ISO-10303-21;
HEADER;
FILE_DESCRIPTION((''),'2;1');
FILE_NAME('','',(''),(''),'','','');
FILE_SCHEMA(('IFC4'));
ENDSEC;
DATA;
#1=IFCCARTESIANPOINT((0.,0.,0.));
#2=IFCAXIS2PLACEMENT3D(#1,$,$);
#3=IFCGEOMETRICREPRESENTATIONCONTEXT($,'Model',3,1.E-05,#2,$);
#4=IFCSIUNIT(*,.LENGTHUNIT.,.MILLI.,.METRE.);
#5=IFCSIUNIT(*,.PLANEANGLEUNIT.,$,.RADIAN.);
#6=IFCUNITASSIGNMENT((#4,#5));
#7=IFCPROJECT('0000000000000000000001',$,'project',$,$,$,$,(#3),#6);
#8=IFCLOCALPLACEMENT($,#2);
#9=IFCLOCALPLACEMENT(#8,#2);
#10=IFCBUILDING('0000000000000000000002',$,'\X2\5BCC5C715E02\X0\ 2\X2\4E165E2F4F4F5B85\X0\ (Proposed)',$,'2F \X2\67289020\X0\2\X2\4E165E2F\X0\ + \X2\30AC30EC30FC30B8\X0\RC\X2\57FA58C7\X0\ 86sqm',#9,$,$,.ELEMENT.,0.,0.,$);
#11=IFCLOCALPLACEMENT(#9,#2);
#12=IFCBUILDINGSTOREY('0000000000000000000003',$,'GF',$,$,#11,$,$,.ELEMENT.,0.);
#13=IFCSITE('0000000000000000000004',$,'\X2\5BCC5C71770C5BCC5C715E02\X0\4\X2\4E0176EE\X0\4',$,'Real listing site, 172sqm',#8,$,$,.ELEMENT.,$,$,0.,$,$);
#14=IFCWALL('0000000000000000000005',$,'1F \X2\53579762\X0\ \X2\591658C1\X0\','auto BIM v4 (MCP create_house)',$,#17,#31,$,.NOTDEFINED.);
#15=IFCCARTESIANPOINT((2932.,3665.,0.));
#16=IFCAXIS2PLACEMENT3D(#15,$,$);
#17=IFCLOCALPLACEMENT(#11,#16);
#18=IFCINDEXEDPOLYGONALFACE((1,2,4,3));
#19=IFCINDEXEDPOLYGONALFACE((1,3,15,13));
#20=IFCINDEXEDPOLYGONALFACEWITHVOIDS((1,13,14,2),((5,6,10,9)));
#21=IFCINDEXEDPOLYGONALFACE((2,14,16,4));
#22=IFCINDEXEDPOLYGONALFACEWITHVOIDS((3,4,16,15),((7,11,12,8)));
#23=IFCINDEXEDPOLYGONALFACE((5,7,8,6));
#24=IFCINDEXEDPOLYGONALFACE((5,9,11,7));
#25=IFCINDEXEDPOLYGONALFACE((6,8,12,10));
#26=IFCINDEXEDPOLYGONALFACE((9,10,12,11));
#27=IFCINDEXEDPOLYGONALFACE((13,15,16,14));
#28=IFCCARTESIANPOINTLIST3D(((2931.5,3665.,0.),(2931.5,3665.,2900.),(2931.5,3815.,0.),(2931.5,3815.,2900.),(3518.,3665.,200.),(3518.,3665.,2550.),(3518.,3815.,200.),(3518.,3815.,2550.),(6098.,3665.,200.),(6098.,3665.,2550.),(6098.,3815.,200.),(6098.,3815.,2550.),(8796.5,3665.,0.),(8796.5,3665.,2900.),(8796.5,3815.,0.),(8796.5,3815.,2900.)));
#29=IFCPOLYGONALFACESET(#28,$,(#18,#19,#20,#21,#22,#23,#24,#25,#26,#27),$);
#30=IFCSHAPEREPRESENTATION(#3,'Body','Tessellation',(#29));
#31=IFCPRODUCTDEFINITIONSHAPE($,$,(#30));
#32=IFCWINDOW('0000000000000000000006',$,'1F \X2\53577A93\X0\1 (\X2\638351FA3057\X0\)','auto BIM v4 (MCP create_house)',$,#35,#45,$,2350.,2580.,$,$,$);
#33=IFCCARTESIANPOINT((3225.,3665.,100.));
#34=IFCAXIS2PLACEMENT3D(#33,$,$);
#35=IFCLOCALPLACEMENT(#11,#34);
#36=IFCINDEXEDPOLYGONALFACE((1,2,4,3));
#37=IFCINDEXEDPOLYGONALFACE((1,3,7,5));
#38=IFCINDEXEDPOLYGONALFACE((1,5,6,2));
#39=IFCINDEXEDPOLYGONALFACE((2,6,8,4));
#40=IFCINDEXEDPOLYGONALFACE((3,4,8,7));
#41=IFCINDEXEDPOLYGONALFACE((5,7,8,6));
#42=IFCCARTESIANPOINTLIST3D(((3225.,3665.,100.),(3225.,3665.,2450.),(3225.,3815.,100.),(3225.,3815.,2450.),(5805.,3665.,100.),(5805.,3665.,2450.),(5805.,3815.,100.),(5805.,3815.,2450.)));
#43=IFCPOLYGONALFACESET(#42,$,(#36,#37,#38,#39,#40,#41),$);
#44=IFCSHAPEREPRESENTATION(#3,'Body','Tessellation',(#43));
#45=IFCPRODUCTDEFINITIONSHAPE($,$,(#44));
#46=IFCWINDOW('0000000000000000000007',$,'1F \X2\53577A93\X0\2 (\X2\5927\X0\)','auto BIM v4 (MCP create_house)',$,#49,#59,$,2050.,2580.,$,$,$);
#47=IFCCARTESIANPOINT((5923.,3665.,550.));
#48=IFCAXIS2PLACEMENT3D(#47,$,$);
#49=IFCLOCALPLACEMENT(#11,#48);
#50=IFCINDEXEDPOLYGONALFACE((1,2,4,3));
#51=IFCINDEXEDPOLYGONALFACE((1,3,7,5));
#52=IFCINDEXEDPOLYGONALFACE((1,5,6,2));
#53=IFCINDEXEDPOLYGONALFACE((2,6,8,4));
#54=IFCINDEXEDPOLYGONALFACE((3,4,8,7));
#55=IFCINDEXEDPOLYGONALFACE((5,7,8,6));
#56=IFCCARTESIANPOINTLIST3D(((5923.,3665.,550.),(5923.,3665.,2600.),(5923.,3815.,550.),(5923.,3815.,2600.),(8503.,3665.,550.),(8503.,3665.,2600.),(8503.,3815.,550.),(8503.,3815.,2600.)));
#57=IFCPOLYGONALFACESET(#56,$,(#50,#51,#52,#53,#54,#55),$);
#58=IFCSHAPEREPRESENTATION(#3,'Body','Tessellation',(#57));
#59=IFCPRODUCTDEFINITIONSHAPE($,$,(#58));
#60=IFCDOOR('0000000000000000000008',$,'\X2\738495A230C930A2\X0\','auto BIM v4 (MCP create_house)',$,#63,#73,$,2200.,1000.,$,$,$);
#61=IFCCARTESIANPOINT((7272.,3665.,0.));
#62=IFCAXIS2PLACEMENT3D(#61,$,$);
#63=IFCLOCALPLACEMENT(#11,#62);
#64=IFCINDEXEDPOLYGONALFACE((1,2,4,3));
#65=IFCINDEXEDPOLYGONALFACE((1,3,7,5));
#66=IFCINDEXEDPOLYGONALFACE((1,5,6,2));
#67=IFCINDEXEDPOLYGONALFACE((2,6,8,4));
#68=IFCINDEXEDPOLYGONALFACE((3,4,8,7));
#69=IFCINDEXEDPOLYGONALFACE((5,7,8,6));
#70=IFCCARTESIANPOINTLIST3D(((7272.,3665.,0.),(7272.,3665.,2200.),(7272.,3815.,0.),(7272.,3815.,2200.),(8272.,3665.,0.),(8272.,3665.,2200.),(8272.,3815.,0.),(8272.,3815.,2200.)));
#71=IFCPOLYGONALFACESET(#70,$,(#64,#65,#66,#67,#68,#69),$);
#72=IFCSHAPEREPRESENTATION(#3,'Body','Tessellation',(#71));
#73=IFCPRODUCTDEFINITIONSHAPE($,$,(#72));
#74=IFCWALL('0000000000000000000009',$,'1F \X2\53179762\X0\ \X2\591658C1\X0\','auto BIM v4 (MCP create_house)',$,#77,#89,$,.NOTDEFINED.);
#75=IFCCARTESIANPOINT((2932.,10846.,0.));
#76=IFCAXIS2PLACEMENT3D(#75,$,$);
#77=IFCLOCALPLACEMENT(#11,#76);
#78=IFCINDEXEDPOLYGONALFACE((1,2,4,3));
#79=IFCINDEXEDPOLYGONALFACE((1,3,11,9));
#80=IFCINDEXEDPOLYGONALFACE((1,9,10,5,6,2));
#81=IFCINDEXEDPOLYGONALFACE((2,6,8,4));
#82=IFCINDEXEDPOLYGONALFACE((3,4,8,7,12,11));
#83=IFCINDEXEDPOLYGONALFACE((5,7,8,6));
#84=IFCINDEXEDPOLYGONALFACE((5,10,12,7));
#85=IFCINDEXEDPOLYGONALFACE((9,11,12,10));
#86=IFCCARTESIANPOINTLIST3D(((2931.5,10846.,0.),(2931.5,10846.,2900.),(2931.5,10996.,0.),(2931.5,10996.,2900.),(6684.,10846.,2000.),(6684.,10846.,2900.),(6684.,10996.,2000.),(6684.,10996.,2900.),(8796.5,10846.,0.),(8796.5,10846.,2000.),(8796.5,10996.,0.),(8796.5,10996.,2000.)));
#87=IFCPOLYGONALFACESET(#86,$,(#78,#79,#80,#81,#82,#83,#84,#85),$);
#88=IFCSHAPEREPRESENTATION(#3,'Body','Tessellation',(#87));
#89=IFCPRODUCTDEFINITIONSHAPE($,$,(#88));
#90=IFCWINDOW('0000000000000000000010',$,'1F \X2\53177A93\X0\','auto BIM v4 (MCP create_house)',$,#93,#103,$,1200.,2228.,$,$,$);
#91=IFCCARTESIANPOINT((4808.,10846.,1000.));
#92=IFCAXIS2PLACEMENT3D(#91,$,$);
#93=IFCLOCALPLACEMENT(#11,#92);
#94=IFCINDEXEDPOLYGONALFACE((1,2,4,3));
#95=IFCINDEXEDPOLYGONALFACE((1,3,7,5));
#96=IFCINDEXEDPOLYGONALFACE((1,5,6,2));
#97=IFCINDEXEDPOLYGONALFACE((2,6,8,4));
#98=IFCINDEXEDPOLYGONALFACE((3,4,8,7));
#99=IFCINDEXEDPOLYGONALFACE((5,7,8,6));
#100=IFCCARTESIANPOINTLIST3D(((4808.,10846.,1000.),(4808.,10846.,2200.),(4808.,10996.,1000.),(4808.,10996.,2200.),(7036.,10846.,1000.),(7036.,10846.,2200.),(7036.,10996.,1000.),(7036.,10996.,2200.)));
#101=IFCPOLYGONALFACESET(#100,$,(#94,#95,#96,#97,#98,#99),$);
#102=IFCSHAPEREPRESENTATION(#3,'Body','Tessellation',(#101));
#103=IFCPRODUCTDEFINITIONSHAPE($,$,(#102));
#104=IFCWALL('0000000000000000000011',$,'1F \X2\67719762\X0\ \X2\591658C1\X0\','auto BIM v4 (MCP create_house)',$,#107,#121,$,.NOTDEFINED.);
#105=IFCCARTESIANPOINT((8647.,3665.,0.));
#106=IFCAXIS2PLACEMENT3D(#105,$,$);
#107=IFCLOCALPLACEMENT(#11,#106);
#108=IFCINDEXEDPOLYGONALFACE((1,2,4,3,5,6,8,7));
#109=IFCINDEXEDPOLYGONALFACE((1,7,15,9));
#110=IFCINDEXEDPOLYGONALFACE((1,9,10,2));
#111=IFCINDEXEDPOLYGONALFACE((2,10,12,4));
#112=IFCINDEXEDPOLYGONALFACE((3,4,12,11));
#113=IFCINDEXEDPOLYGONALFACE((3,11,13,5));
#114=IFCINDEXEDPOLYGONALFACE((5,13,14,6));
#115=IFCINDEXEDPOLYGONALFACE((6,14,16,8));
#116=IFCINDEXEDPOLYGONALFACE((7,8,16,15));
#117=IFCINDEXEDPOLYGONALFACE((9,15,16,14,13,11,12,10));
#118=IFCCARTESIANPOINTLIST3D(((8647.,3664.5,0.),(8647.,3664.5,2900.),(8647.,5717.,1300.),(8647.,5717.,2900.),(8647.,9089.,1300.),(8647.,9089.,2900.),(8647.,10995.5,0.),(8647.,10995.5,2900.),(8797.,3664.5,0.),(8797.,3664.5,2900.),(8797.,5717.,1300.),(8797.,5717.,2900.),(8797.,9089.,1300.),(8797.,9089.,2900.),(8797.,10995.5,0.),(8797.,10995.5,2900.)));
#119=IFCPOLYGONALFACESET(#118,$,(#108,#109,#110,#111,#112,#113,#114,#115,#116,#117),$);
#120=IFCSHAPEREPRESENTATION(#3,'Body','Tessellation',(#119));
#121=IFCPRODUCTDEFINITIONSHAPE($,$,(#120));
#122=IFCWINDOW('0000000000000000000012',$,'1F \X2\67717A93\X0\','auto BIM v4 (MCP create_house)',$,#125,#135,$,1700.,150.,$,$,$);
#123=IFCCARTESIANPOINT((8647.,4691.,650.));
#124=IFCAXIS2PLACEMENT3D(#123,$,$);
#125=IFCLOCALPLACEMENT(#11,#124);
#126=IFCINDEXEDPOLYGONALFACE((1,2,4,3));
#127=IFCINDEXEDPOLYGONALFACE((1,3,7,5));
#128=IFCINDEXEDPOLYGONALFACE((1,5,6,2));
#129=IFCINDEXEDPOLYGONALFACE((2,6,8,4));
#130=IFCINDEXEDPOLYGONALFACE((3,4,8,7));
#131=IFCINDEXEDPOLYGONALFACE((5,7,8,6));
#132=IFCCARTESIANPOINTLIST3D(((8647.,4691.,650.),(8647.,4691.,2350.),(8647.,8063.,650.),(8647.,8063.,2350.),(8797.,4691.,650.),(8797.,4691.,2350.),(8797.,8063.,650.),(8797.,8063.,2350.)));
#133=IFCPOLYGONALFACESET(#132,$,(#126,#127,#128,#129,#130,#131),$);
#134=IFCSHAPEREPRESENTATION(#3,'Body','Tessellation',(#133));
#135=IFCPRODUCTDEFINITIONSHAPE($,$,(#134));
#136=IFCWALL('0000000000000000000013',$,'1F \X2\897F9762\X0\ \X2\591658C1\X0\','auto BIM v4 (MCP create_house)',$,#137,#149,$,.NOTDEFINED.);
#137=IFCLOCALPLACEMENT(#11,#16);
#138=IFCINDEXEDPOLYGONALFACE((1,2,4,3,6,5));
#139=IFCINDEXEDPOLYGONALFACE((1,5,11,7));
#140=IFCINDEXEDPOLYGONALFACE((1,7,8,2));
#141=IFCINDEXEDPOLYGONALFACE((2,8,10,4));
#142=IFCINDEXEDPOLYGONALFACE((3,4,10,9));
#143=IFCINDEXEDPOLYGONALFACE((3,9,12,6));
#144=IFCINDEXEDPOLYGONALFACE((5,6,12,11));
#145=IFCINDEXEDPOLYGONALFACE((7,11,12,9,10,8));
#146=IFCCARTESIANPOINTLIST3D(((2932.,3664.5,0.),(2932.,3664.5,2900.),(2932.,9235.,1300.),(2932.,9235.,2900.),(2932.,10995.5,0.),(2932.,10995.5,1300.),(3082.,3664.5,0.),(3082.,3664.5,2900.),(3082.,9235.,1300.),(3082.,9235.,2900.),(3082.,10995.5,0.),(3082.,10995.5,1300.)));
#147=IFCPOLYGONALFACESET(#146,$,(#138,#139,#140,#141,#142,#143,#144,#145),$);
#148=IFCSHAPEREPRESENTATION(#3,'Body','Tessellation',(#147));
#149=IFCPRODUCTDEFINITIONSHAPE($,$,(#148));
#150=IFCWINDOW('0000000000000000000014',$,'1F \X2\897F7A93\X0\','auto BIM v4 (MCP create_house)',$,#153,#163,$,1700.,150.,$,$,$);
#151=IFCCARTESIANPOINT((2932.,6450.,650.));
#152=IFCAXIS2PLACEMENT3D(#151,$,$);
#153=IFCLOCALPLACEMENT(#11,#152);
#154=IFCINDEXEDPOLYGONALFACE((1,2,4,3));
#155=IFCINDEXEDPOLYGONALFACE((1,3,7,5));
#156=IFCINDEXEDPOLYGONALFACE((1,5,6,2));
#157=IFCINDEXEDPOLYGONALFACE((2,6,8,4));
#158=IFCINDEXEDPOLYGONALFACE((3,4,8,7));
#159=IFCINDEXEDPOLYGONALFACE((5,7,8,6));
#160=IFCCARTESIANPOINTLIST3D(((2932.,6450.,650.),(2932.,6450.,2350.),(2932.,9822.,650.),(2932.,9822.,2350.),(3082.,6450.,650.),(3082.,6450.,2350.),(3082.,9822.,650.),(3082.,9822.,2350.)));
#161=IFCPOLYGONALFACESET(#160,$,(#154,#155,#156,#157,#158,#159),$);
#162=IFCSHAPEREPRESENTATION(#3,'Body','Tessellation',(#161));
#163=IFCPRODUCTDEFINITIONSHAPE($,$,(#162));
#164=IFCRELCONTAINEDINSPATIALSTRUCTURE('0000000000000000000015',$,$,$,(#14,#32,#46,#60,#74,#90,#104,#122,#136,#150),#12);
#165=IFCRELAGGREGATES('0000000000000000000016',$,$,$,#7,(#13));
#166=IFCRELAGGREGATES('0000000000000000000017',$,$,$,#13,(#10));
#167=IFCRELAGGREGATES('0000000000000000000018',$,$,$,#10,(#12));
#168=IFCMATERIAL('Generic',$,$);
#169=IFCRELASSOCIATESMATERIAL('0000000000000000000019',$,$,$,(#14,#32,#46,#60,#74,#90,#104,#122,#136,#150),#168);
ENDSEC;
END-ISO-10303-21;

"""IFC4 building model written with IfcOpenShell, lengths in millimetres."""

from ifc_helpers import new_model, si_unit, frame, frame_2d, origin, place, context, project, spatial, rectangle, extrude, material, element, fill, save


model = new_model("IFC4")

# Units and contexts
model_context = context("Model", 3, precision=1e-05, world=origin())
ifc_project = project(units=[si_unit("LENGTHUNIT", "METRE", prefix="MILLI"), si_unit("PLANEANGLEUNIT", "RADIAN")], contexts=[model_context])

# Site, building, storey
site_placement = place(None, origin())
site = spatial("IfcSite", under=ifc_project, at=site_placement, Name="富山県富山市4丁目4", ObjectType="Real listing site, 172sqm", CompositionType="ELEMENT", RefElevation=0.0)
building_placement = place(site_placement, origin())
building = spatial("IfcBuilding", under=site, at=building_placement, Name="富山市 2世帯住宅 (Proposed)", ObjectType="2F 木造2世帯 + ガレージRC基壇 86sqm", CompositionType="ELEMENT", ElevationOfRefHeight=0.0, ElevationOfTerrain=0.0)
storey_placement = place(building_placement, origin())
storey = spatial("IfcBuildingStorey", under=building, at=storey_placement, Name="GF", CompositionType="ELEMENT", Elevation=0.0)

# Shared definitions
ifc_material = material(Name="Generic")

# Wall, openings, windows, door
wall_1_placement = place(storey_placement, frame((2932.0, 3665.0, 0.0)))
wall_1 = element("IfcWall", 1, at=wall_1_placement, inside=storey, material=ifc_material, Name="1F 南面 外壁", Description="auto BIM v4 (MCP create_house)", PredefinedType="NOTDEFINED", context=model_context, shape_type="SweptSolid", body=[
    extrude(rectangle(XDim=5865.0, YDim=150.0, at=frame_2d((2932.0, 75.0))), frame((2932.0, 3665.0, 0.0)), (0.0, 0.0, 1.0), 2900.0),
])
opening_1_placement = place(storey_placement, frame((3225.0, 3665.0, 100.0)))
opening_1 = element("IfcOpeningElement", 2, at=opening_1_placement, cuts=wall_1, PredefinedType="NOTDEFINED", context=model_context, shape_type="SweptSolid", body=[
    extrude(rectangle(XDim=2580.0, YDim=150.0, at=frame_2d((1290.0, 75.0))), frame((3225.0, 3665.0, 100.0)), (0.0, 0.0, 1.0), 2350.0),
])
opening_2_placement = place(storey_placement, frame((5923.0, 3665.0, 550.0)))
opening_2 = element("IfcOpeningElement", 3, at=opening_2_placement, cuts=wall_1, PredefinedType="NOTDEFINED", context=model_context, shape_type="SweptSolid", body=[
    extrude(rectangle(XDim=2580.0, YDim=150.0, at=frame_2d((1290.0, 75.0))), frame((5923.0, 3665.0, 550.0)), (0.0, 0.0, 1.0), 2050.0),
])
opening_3_placement = place(storey_placement, frame((7272.0, 3665.0, 0.0)))
opening_3 = element("IfcOpeningElement", 4, at=opening_3_placement, cuts=wall_1, PredefinedType="NOTDEFINED", context=model_context, shape_type="SweptSolid", body=[
    extrude(rectangle(XDim=1000.0, YDim=150.0, at=frame_2d((500.0, 75.0))), frame((7272.0, 3665.0, 0.0)), (0.0, 0.0, 1.0), 2200.0),
])
window_1_placement = place(storey_placement, frame((3225.0, 3665.0, 100.0)))
window_1 = element("IfcWindow", 5, at=window_1_placement, inside=storey, material=ifc_material, Name="1F 南窓1 (掃出し)", Description="auto BIM v4 (MCP create_house)", OverallHeight=2350.0, OverallWidth=2580.0, context=model_context, shape_type="SweptSolid", body=[
    extrude(rectangle(XDim=2580.0, YDim=150.0, at=frame_2d((1290.0, 75.0))), frame((3225.0, 3665.0, 100.0)), (0.0, 0.0, 1.0), 2350.0),
])
fill(opening_1, window_1)
window_2_placement = place(storey_placement, frame((5923.0, 3665.0, 550.0)))
window_2 = element("IfcWindow", 6, at=window_2_placement, inside=storey, material=ifc_material, Name="1F 南窓2 (大)", Description="auto BIM v4 (MCP create_house)", OverallHeight=2050.0, OverallWidth=2580.0, context=model_context, shape_type="SweptSolid", body=[
    extrude(rectangle(XDim=2580.0, YDim=150.0, at=frame_2d((1290.0, 75.0))), frame((5923.0, 3665.0, 550.0)), (0.0, 0.0, 1.0), 2050.0),
])
fill(opening_2, window_2)
door_1_placement = place(storey_placement, frame((7272.0, 3665.0, 0.0)))
door_1 = element("IfcDoor", 7, at=door_1_placement, inside=storey, material=ifc_material, Name="玄関ドア", Description="auto BIM v4 (MCP create_house)", OverallHeight=2200.0, OverallWidth=1000.0, context=model_context, shape_type="SweptSolid", body=[
    extrude(rectangle(XDim=1000.0, YDim=150.0, at=frame_2d((500.0, 75.0))), frame((7272.0, 3665.0, 0.0)), (0.0, 0.0, 1.0), 2200.0),
])
fill(opening_3, door_1)

# Walls, openings, windows
wall_2_placement = place(storey_placement, frame((2932.0, 10846.0, 0.0)))
wall_2 = element("IfcWall", 8, at=wall_2_placement, inside=storey, material=ifc_material, Name="1F 北面 外壁", Description="auto BIM v4 (MCP create_house)", PredefinedType="NOTDEFINED", context=model_context, shape_type="SweptSolid", body=[
    extrude(rectangle(XDim=5865.0, YDim=150.0, at=frame_2d((2932.0, 75.0))), frame((2932.0, 10846.0, 0.0)), (0.0, 0.0, 1.0), 2900.0),
])
opening_4_placement = place(storey_placement, frame((4808.0, 10846.0, 1000.0)))
opening_4 = element("IfcOpeningElement", 9, at=opening_4_placement, cuts=wall_2, PredefinedType="NOTDEFINED", context=model_context, shape_type="SweptSolid", body=[
    extrude(rectangle(XDim=2228.0, YDim=150.0, at=frame_2d((1114.0, 75.0))), frame((4808.0, 10846.0, 1000.0)), (0.0, 0.0, 1.0), 1200.0),
])
window_3_placement = place(storey_placement, frame((4808.0, 10846.0, 1000.0)))
window_3 = element("IfcWindow", 10, at=window_3_placement, inside=storey, material=ifc_material, Name="1F 北窓", Description="auto BIM v4 (MCP create_house)", OverallHeight=1200.0, OverallWidth=2228.0, context=model_context, shape_type="SweptSolid", body=[
    extrude(rectangle(XDim=2228.0, YDim=150.0, at=frame_2d((1114.0, 75.0))), frame((4808.0, 10846.0, 1000.0)), (0.0, 0.0, 1.0), 1200.0),
])
fill(opening_4, window_3)
wall_3_placement = place(storey_placement, frame((8647.0, 3665.0, 0.0)))
wall_3 = element("IfcWall", 11, at=wall_3_placement, inside=storey, material=ifc_material, Name="1F 東面 外壁", Description="auto BIM v4 (MCP create_house)", PredefinedType="NOTDEFINED", context=model_context, shape_type="SweptSolid", body=[
    extrude(rectangle(XDim=150.0, YDim=7331.0, at=frame_2d((75.0, 3665.0))), frame((8647.0, 3665.0, 0.0)), (0.0, 0.0, 1.0), 2900.0),
])
opening_5_placement = place(storey_placement, frame((8647.0, 4691.0, 650.0)))
opening_5 = element("IfcOpeningElement", 12, at=opening_5_placement, cuts=wall_3, PredefinedType="NOTDEFINED", context=model_context, shape_type="SweptSolid", body=[
    extrude(rectangle(XDim=150.0, YDim=3372.0, at=frame_2d((75.0, 1686.0))), frame((8647.0, 4691.0, 650.0)), (0.0, 0.0, 1.0), 1700.0),
])
window_4_placement = place(storey_placement, frame((8647.0, 4691.0, 650.0)))
window_4 = element("IfcWindow", 13, at=window_4_placement, inside=storey, material=ifc_material, Name="1F 東窓", Description="auto BIM v4 (MCP create_house)", OverallHeight=1700.0, OverallWidth=150.0, context=model_context, shape_type="SweptSolid", body=[
    extrude(rectangle(XDim=150.0, YDim=3372.0, at=frame_2d((75.0, 1686.0))), frame((8647.0, 4691.0, 650.0)), (0.0, 0.0, 1.0), 1700.0),
])
fill(opening_5, window_4)
wall_4_placement = place(storey_placement, frame((2932.0, 3665.0, 0.0)))
wall_4 = element("IfcWall", 14, at=wall_4_placement, inside=storey, material=ifc_material, Name="1F 西面 外壁", Description="auto BIM v4 (MCP create_house)", PredefinedType="NOTDEFINED", context=model_context, shape_type="SweptSolid", body=[
    extrude(rectangle(XDim=150.0, YDim=7331.0, at=frame_2d((75.0, 3665.0))), frame((2932.0, 3665.0, 0.0)), (0.0, 0.0, 1.0), 2900.0),
])
opening_6_placement = place(storey_placement, frame((2932.0, 6450.0, 650.0)))
opening_6 = element("IfcOpeningElement", 15, at=opening_6_placement, cuts=wall_4, PredefinedType="NOTDEFINED", context=model_context, shape_type="SweptSolid", body=[
    extrude(rectangle(XDim=150.0, YDim=3372.0, at=frame_2d((75.0, 1686.0))), frame((2932.0, 6450.0, 650.0)), (0.0, 0.0, 1.0), 1700.0),
])
window_5_placement = place(storey_placement, frame((2932.0, 6450.0, 650.0)))
window_5 = element("IfcWindow", 16, at=window_5_placement, inside=storey, material=ifc_material, Name="1F 西窓", Description="auto BIM v4 (MCP create_house)", OverallHeight=1700.0, OverallWidth=150.0, context=model_context, shape_type="SweptSolid", body=[
    extrude(rectangle(XDim=150.0, YDim=3372.0, at=frame_2d((75.0, 1686.0))), frame((2932.0, 6450.0, 650.0)), (0.0, 0.0, 1.0), 1700.0),
])
fill(opening_6, window_5)

save(model, "model.ifc")
